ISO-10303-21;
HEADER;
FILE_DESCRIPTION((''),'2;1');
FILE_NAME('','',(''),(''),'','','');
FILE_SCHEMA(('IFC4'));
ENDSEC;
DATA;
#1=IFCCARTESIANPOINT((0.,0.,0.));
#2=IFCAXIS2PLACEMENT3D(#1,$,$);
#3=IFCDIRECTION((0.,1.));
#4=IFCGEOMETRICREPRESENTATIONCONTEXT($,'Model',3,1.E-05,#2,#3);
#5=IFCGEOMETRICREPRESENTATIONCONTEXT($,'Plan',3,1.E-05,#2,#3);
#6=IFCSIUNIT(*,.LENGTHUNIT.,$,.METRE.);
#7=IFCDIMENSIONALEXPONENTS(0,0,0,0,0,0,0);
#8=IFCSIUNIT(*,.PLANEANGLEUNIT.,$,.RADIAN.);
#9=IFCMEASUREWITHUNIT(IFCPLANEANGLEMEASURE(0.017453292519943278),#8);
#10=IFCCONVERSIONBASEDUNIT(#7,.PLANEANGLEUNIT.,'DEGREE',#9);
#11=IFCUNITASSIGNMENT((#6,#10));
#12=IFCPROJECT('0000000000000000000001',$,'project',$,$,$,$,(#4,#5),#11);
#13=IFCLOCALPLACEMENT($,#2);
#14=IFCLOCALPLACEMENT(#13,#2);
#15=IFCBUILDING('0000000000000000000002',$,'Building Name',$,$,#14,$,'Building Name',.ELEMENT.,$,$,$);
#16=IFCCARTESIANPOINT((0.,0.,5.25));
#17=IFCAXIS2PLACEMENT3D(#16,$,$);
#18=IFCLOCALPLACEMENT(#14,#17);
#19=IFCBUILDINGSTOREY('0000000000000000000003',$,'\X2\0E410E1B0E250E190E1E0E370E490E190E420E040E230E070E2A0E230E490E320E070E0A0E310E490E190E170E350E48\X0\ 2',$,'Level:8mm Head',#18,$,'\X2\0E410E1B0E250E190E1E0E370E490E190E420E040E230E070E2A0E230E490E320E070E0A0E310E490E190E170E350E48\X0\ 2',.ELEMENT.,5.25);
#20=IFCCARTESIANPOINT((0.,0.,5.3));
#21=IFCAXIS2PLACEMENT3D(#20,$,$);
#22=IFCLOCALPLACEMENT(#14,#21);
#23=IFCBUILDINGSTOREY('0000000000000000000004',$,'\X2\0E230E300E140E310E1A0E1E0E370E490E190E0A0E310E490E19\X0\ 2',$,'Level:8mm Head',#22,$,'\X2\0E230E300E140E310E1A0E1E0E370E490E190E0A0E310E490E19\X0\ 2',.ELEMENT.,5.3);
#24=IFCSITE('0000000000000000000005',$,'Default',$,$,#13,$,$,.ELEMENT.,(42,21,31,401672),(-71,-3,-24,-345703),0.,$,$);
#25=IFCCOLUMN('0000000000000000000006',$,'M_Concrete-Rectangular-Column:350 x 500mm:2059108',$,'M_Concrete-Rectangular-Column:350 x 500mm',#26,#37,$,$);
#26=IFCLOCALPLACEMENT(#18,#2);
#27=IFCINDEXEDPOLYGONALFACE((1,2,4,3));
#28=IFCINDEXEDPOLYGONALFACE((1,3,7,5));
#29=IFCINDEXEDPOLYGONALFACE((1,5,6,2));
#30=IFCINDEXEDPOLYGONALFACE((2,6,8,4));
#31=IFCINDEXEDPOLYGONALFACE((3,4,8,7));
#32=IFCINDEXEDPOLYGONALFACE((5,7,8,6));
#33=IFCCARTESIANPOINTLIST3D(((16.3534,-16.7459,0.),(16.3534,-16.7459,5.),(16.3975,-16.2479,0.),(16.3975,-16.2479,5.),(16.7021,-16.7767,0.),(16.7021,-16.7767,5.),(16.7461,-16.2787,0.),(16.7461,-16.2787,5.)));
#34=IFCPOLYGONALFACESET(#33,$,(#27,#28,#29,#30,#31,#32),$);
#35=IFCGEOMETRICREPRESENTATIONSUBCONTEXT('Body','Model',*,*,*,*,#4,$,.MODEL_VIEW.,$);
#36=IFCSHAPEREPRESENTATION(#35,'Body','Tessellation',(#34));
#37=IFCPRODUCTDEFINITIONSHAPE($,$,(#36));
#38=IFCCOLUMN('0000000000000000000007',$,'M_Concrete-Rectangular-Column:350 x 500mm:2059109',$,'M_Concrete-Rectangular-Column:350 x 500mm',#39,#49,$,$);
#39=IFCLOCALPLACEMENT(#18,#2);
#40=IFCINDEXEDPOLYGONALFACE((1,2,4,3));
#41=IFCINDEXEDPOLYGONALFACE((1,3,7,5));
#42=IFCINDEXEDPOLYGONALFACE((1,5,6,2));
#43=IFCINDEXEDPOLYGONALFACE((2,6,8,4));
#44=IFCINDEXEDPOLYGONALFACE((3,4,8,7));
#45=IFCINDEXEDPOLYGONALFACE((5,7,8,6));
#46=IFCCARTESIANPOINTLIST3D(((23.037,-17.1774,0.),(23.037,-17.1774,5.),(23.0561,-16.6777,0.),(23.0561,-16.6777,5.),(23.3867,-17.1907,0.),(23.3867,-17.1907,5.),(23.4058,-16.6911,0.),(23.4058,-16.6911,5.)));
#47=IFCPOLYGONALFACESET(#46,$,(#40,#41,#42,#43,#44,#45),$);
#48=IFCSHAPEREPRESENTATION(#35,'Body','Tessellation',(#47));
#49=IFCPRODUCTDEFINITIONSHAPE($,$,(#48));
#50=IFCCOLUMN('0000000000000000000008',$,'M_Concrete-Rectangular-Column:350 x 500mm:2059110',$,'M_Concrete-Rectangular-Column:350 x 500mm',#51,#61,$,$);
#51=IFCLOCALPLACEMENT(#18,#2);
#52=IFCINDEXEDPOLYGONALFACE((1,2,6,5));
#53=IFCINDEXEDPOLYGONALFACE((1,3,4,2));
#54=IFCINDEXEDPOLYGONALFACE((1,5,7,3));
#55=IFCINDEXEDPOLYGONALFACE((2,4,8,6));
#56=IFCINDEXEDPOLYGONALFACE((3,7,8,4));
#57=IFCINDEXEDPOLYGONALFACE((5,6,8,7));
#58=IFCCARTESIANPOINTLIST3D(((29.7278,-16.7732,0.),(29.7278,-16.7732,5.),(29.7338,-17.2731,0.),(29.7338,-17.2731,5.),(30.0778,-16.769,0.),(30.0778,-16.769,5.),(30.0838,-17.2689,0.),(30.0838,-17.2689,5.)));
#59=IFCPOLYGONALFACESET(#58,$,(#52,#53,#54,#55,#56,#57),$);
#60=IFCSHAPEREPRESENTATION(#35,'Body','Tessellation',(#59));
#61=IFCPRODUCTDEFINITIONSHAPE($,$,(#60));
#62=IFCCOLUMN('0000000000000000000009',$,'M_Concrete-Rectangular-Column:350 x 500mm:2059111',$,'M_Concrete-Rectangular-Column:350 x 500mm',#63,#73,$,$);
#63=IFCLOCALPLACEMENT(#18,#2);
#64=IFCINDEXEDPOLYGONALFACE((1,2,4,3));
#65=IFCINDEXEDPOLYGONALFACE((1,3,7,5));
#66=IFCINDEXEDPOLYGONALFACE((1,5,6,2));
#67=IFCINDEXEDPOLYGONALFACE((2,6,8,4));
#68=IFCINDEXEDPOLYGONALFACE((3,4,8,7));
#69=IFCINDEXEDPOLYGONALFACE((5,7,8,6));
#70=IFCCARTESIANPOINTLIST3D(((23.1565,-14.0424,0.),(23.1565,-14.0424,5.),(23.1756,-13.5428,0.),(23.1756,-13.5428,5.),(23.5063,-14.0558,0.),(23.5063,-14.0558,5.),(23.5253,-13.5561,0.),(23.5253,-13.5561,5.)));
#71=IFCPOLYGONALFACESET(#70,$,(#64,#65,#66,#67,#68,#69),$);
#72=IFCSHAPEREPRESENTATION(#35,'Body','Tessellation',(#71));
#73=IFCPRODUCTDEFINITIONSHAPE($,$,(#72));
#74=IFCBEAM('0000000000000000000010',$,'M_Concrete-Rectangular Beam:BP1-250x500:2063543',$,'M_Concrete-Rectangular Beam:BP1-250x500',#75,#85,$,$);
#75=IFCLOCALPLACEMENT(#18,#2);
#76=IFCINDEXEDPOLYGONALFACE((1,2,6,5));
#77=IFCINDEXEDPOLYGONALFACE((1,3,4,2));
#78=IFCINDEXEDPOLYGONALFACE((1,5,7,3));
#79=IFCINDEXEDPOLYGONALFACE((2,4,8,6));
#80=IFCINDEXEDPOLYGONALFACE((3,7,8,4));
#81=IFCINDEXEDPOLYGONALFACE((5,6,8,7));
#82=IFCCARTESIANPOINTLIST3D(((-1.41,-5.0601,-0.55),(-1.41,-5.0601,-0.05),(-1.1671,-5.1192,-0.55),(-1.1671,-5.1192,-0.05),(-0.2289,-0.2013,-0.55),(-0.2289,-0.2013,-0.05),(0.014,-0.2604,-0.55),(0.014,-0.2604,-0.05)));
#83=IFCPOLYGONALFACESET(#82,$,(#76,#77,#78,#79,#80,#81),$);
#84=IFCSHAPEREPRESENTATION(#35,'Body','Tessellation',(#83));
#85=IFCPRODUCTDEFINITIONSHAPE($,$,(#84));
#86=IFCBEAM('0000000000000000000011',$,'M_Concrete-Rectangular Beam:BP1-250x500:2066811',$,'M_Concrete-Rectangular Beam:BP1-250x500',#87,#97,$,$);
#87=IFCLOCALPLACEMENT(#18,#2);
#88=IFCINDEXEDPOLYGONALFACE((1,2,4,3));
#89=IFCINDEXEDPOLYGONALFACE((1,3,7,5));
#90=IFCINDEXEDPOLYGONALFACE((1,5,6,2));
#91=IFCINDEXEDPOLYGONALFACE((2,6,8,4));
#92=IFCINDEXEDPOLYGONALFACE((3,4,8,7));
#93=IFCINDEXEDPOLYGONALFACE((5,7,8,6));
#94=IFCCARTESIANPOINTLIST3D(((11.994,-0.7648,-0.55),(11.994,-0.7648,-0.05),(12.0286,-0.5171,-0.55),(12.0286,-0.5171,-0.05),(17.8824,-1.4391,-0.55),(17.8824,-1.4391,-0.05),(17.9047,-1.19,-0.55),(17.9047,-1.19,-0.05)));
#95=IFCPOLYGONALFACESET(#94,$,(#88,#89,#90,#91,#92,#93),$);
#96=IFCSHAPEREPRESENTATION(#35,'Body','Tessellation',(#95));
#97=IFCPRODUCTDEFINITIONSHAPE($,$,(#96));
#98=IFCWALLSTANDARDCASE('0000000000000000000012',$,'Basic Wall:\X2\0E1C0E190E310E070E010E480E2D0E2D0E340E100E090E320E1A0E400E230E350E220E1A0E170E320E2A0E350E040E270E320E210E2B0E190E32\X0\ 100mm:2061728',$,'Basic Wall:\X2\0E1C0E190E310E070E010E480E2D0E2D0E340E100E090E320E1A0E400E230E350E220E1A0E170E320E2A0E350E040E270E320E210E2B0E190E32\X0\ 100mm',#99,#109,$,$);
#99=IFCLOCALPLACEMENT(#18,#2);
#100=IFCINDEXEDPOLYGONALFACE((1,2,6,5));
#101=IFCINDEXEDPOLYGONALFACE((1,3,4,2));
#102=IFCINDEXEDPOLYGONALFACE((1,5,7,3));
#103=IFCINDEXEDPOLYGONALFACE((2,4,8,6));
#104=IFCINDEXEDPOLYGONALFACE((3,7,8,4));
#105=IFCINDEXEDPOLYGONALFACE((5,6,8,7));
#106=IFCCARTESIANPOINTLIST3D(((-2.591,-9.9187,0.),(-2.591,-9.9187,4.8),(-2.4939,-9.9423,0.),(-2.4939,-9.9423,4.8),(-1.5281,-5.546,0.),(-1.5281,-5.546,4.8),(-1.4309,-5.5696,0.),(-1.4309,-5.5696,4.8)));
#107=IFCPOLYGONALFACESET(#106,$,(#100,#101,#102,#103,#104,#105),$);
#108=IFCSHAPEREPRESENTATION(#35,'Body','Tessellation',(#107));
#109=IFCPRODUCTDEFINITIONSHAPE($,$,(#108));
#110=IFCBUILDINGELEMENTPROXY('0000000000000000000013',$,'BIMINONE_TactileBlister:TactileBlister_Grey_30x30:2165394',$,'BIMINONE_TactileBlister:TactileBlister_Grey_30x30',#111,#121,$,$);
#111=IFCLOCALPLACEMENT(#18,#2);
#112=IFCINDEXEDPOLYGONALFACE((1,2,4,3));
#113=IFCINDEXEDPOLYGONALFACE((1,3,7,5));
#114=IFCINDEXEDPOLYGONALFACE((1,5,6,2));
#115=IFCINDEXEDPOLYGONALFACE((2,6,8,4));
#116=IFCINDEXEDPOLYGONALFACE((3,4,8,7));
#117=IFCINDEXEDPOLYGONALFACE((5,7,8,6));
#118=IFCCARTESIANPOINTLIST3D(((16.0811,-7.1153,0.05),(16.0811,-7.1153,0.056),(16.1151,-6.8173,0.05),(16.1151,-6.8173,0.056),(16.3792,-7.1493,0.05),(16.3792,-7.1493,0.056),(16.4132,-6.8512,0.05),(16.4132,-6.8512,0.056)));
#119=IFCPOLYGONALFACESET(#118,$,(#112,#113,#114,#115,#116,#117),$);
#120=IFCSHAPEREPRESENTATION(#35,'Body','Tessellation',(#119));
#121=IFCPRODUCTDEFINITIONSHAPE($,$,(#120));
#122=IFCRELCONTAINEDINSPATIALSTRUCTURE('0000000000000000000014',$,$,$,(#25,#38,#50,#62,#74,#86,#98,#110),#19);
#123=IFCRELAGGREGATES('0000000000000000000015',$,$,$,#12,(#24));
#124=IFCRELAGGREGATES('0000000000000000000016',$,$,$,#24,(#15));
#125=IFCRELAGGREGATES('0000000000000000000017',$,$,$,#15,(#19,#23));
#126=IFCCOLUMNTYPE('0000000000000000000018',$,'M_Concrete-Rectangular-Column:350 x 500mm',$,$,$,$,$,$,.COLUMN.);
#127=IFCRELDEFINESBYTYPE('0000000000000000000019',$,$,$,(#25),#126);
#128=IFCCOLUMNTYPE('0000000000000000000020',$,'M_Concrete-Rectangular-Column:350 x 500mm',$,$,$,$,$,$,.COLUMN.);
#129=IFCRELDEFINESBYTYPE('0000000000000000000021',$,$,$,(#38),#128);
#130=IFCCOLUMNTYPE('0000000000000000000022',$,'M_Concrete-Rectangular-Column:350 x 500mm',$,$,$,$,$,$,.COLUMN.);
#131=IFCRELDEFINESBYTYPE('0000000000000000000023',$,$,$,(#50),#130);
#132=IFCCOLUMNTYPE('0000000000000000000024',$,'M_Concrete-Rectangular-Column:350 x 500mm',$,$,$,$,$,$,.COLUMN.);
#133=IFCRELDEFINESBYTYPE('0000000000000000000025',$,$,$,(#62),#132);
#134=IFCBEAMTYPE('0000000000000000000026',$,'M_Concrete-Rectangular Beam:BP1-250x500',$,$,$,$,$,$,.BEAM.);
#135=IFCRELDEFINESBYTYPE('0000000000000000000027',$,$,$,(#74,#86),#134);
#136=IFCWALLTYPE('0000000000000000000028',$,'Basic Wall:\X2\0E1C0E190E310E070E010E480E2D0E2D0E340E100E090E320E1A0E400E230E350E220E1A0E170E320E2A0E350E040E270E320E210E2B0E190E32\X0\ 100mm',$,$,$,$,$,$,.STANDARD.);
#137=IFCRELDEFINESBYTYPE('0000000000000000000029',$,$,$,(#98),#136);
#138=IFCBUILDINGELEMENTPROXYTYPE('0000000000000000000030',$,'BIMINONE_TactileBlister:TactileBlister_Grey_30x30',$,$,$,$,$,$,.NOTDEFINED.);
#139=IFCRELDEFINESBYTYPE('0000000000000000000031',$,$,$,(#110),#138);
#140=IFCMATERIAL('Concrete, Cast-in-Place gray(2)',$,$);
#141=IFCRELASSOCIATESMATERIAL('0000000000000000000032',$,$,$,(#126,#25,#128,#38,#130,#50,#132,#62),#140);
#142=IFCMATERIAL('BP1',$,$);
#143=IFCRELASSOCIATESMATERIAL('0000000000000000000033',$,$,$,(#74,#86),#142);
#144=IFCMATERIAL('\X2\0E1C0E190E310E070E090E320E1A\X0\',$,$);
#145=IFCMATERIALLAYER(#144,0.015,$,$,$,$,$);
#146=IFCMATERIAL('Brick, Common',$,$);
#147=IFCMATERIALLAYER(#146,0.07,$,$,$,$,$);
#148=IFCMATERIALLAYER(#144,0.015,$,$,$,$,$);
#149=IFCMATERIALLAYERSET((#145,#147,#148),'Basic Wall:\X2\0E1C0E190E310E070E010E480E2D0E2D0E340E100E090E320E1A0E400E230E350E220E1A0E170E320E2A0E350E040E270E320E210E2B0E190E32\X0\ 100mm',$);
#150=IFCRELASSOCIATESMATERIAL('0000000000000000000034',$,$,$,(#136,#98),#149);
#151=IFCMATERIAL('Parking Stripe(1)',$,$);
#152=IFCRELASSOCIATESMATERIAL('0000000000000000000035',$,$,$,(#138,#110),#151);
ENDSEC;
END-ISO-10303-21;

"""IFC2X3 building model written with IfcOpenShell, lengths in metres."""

from ifc_helpers import new_model, entity, si_unit, converted_unit, direction, frame, frame_2d, origin, origin_2d_with_axis, place, context, subcontext, project, spatial, rectangle, extrude, clip, halfspace, source, transform, mapped, material, layer, layer_set, layer_usage, type_object, type_shapes, element, save


model = new_model("IFC2X3")

# Units and contexts
model_context = context("Model", 3, precision=1e-05, world=origin(), true_north=direction((0.0, 1.0)))
plan_context = context("Plan", 3, precision=1e-05, world=origin(), true_north=direction((0.0, 1.0)))
body_context = subcontext(model_context, "Body", "Model", "MODEL_VIEW")
ifc_project = project(units=[si_unit("LENGTHUNIT", "METRE"), converted_unit("PLANEANGLEUNIT", "DEGREE", entity("IfcPlaneAngleMeasure", 0.017453292519943278), si_unit("PLANEANGLEUNIT", "RADIAN"), dimensions=[0, 0, 0, 0, 0, 0, 0])], contexts=[model_context, plan_context])

# Site, building, storey
site_placement = place(None, origin())
site = spatial("IfcSite", under=ifc_project, at=site_placement, Name="Default", CompositionType="ELEMENT", RefLatitude=(42, 21, 31, 401672), RefLongitude=(-71, -3, -24, -345703), RefElevation=0.0)
building_placement = place(site_placement, origin())
building = spatial("IfcBuilding", under=site, at=building_placement, Name="Building Name", LongName="Building Name", CompositionType="ELEMENT")
storey_1_placement = place(building_placement, frame((0.0, 0.0, 5.25)))
storey_1 = spatial("IfcBuildingStorey", under=building, at=storey_1_placement, Name="แปลนพื้นโครงสร้างชั้นที่ 2", ObjectType="Level:8mm Head", LongName="แปลนพื้นโครงสร้างชั้นที่ 2", CompositionType="ELEMENT", Elevation=5.25)

# Columns
ifc_material_1 = material(Name="Concrete, Cast-in-Place gray(2)")
column_type_1 = type_object("IfcColumnType", Name="M_Concrete-Rectangular-Column:350 x 500mm", PredefinedType="COLUMN", material=ifc_material_1)
shared_shape_1 = source(origin(), body_context, "Body", "SweptSolid", [
    extrude(rectangle(XDim=0.35, YDim=0.5, at=frame_2d((0.0, 0.0), x_axis=(1.0, 0.0))), frame((16.5498, -16.5123, 5.25), z_axis=(0.0, 0.0, 1.0), x_axis=(0.996113, -0.088086, 0.0)), (0.0, 0.0, 1.0), 5.0),
])
type_shapes(column_type_1, [shared_shape_1])
column_1_placement = place(storey_1_placement, frame((0.0, 0.0, -5.25)))
element("IfcColumn", 1, at=column_1_placement, inside=storey_1, type_object=column_type_1, material=ifc_material_1, Name="M_Concrete-Rectangular-Column:350 x 500mm:2059108", ObjectType="M_Concrete-Rectangular-Column:350 x 500mm", context=body_context, shape_type="MappedRepresentation", body=[
    mapped(shared_shape_1, transform((0.0, 0.0, 0.0), scale=1.0)),
])
column_type_2 = type_object("IfcColumnType", Name="M_Concrete-Rectangular-Column:350 x 500mm", PredefinedType="COLUMN", material=ifc_material_1)
shared_shape_2 = source(origin(), body_context, "Body", "SweptSolid", [
    extrude(rectangle(XDim=0.35, YDim=0.5, at=frame_2d((0.0, 0.0), x_axis=(1.0, 0.0))), frame((23.2214, -16.9342, 5.25), z_axis=(0.0, 0.0, 1.0), x_axis=(0.999274, -0.038106, 0.0)), (0.0, 0.0, 1.0), 5.0),
])
type_shapes(column_type_2, [shared_shape_2])
column_2_placement = place(storey_1_placement, frame((0.0, 0.0, -5.25)))
element("IfcColumn", 2, at=column_2_placement, inside=storey_1, type_object=column_type_2, material=ifc_material_1, Name="M_Concrete-Rectangular-Column:350 x 500mm:2059109", ObjectType="M_Concrete-Rectangular-Column:350 x 500mm", context=body_context, shape_type="MappedRepresentation", body=[
    mapped(shared_shape_2, transform((0.0, 0.0, 0.0), scale=1.0)),
])
column_type_3 = type_object("IfcColumnType", Name="M_Concrete-Rectangular-Column:350 x 500mm", PredefinedType="COLUMN", material=ifc_material_1)
shared_shape_3 = source(origin(), body_context, "Body", "SweptSolid", [
    extrude(rectangle(XDim=0.35, YDim=0.5, at=frame_2d((0.0, 0.0), x_axis=(1.0, 0.0))), frame((29.9058, -17.0211, 5.25), z_axis=(0.0, 0.0, 1.0), x_axis=(0.999928, 0.011969, 0.0)), (0.0, 0.0, 1.0), 5.0),
])
type_shapes(column_type_3, [shared_shape_3])
column_3_placement = place(storey_1_placement, frame((0.0, 0.0, -5.25)))
element("IfcColumn", 3, at=column_3_placement, inside=storey_1, type_object=column_type_3, material=ifc_material_1, Name="M_Concrete-Rectangular-Column:350 x 500mm:2059110", ObjectType="M_Concrete-Rectangular-Column:350 x 500mm", context=body_context, shape_type="MappedRepresentation", body=[
    mapped(shared_shape_3, transform((0.0, 0.0, 0.0), scale=1.0)),
])
column_type_4 = type_object("IfcColumnType", Name="M_Concrete-Rectangular-Column:350 x 500mm", PredefinedType="COLUMN", material=ifc_material_1)
shared_shape_4 = source(origin(), body_context, "Body", "SweptSolid", [
    extrude(rectangle(XDim=0.35, YDim=0.5, at=frame_2d((0.0, 0.0), x_axis=(1.0, 0.0))), frame((23.3409, -13.7993, 5.25), z_axis=(0.0, 0.0, 1.0), x_axis=(0.999274, -0.038106, 0.0)), (0.0, 0.0, 1.0), 5.0),
])
type_shapes(column_type_4, [shared_shape_4])
column_4_placement = place(storey_1_placement, frame((0.0, 0.0, -5.25)))
element("IfcColumn", 4, at=column_4_placement, inside=storey_1, type_object=column_type_4, material=ifc_material_1, Name="M_Concrete-Rectangular-Column:350 x 500mm:2059111", ObjectType="M_Concrete-Rectangular-Column:350 x 500mm", context=body_context, shape_type="MappedRepresentation", body=[
    mapped(shared_shape_4, transform((0.0, 0.0, 0.0), scale=1.0)),
])

# Beams
ifc_material_2 = material(Name="BP1")
beam_type = type_object("IfcBeamType", Name="M_Concrete-Rectangular Beam:BP1-250x500", PredefinedType="BEAM")
beam_1_placement = place(storey_1_placement, frame((-1.41, -5.0601, -0.05), z_axis=(0.0, 0.0, 1.0), x_axis=(0.236201, 0.971704, 0.0)))
element("IfcBeam", 5, at=beam_1_placement, inside=storey_1, type_object=beam_type, material=ifc_material_2, Name="M_Concrete-Rectangular Beam:BP1-250x500:2063543", ObjectType="M_Concrete-Rectangular Beam:BP1-250x500", context=body_context, shape_type="SweptSolid", body=[
    extrude(rectangle(XDim=0.5, YDim=0.25, at=frame_2d((0.0, 0.0), x_axis=(1.0, 0.0))), frame((0.0, -0.125, -0.25), z_axis=(1.0, 0.0, 0.0), x_axis=(0.0, 0.0, -1.0)), (0.0, 0.0, 1.0), 5.0003),
])
beam_2_placement = place(storey_1_placement, frame((12.0286, -0.5171, -0.05), z_axis=(0.0, 0.0, 1.0), x_axis=(0.993506, -0.113776, 0.0)))
element("IfcBeam", 6, at=beam_2_placement, inside=storey_1, type_object=beam_type, material=ifc_material_2, Name="M_Concrete-Rectangular Beam:BP1-250x500:2066811", ObjectType="M_Concrete-Rectangular Beam:BP1-250x500", context=body_context, shape_type="Clipping", body=[
    clip(clip(extrude(rectangle(XDim=0.5, YDim=0.25, at=frame_2d((0.0, 0.0), x_axis=(1.0, 0.0))), frame((-0.0062, -0.125, -0.25), z_axis=(1.0, 0.0, 0.0), x_axis=(0.0, 0.0, -1.0)), (0.0, 0.0, 1.0), 5.927), halfspace(frame((0.0, 0.0, 0.0), z_axis=(-0.99969, 0.024883, 0.0), x_axis=(0.024883, 0.99969, 0.0)), False)), halfspace(frame((5.9145, 0.0, 0.0), z_axis=(0.99969, 0.024883, 0.0), x_axis=(-0.024883, 0.99969, 0.0)), False)),
])

# Shared definitions
ifc_material_3 = material(Name="ผนังฉาบ")
ifc_layer_1 = layer(ifc_material_3, 0.015)
ifc_material_4 = material(Name="Brick, Common")
ifc_layer_2 = layer(ifc_material_4, 0.07)
ifc_layer_3 = layer(ifc_material_3, 0.015)
ifc_layer_set = layer_set([ifc_layer_1, ifc_layer_2, ifc_layer_3], Name="Basic Wall:ผนังก่ออิฐฉาบเรียบทาสีความหนา 100mm")
wall_type = type_object("IfcWallType", Name="Basic Wall:ผนังก่ออิฐฉาบเรียบทาสีความหนา 100mm", PredefinedType="STANDARD", material=ifc_layer_set)

# Shared definitions
storey_2_placement = place(building_placement, frame((0.0, 0.0, 5.3)))
storey_2 = spatial("IfcBuildingStorey", under=building, at=storey_2_placement, Name="ระดับพื้นชั้น 2", ObjectType="Level:8mm Head", LongName="ระดับพื้นชั้น 2", CompositionType="ELEMENT", Elevation=5.3)

# Wall
ifc_layer_usage_1 = layer_usage(ifc_layer_set, "AXIS2", "POSITIVE", -0.05)
wall_1_placement = place(storey_1_placement, frame((-1.4795, -5.5578, 0.0), z_axis=(0.0, 0.0, 1.0), x_axis=(-0.236201, -0.971704, 0.0)))
element("IfcWallStandardCase", 7, at=wall_1_placement, inside=storey_1, type_object=wall_type, material=ifc_layer_usage_1, Name="Basic Wall:ผนังก่ออิฐฉาบเรียบทาสีความหนา 100mm:2061728", ObjectType="Basic Wall:ผนังก่ออิฐฉาบเรียบทาสีความหนา 100mm", context=body_context, shape_type="SweptSolid", body=[
    extrude(rectangle(XDim=4.5, YDim=0.1, at=frame_2d((2.25, 0.0), x_axis=(-1.0, 0.0))), origin(), (0.0, 0.0, 1.0), 4.8),
])

# Building element proxy
ifc_material_5 = material(Name="Parking Stripe(1)")
building_element_proxy_type = type_object("IfcBuildingElementProxyType", Name="BIMINONE_TactileBlister:TactileBlister_Grey_30x30", PredefinedType="NOTDEFINED", material=ifc_material_5)
shared_shape_5 = source(origin(), body_context, "Body", "SweptSolid", [
    extrude(rectangle(XDim=0.3, YDim=0.3, at=origin_2d_with_axis()), frame((0.15, -0.15, 0.0), z_axis=(0.0, 0.0, 1.0), x_axis=(-1.0, 0.0, 0.0)), (0.0, 0.0, 1.0), 0.006),
])
type_shapes(building_element_proxy_type, [shared_shape_5])
proxy_placement = place(storey_1_placement, frame((16.0811, -7.1153, 0.05), z_axis=(0.0, 0.0, 1.0), x_axis=(0.113147, 0.993578, 0.0)))
element("IfcBuildingElementProxy", 8, at=proxy_placement, inside=storey_1, type_object=building_element_proxy_type, material=ifc_material_5, Name="BIMINONE_TactileBlister:TactileBlister_Grey_30x30:2165394", ObjectType="BIMINONE_TactileBlister:TactileBlister_Grey_30x30", context=body_context, shape_type="MappedRepresentation", body=[
    mapped(shared_shape_5, transform((0.0, 0.0, 0.0), scale=1.0)),
])

save(model, "model.ifc")
